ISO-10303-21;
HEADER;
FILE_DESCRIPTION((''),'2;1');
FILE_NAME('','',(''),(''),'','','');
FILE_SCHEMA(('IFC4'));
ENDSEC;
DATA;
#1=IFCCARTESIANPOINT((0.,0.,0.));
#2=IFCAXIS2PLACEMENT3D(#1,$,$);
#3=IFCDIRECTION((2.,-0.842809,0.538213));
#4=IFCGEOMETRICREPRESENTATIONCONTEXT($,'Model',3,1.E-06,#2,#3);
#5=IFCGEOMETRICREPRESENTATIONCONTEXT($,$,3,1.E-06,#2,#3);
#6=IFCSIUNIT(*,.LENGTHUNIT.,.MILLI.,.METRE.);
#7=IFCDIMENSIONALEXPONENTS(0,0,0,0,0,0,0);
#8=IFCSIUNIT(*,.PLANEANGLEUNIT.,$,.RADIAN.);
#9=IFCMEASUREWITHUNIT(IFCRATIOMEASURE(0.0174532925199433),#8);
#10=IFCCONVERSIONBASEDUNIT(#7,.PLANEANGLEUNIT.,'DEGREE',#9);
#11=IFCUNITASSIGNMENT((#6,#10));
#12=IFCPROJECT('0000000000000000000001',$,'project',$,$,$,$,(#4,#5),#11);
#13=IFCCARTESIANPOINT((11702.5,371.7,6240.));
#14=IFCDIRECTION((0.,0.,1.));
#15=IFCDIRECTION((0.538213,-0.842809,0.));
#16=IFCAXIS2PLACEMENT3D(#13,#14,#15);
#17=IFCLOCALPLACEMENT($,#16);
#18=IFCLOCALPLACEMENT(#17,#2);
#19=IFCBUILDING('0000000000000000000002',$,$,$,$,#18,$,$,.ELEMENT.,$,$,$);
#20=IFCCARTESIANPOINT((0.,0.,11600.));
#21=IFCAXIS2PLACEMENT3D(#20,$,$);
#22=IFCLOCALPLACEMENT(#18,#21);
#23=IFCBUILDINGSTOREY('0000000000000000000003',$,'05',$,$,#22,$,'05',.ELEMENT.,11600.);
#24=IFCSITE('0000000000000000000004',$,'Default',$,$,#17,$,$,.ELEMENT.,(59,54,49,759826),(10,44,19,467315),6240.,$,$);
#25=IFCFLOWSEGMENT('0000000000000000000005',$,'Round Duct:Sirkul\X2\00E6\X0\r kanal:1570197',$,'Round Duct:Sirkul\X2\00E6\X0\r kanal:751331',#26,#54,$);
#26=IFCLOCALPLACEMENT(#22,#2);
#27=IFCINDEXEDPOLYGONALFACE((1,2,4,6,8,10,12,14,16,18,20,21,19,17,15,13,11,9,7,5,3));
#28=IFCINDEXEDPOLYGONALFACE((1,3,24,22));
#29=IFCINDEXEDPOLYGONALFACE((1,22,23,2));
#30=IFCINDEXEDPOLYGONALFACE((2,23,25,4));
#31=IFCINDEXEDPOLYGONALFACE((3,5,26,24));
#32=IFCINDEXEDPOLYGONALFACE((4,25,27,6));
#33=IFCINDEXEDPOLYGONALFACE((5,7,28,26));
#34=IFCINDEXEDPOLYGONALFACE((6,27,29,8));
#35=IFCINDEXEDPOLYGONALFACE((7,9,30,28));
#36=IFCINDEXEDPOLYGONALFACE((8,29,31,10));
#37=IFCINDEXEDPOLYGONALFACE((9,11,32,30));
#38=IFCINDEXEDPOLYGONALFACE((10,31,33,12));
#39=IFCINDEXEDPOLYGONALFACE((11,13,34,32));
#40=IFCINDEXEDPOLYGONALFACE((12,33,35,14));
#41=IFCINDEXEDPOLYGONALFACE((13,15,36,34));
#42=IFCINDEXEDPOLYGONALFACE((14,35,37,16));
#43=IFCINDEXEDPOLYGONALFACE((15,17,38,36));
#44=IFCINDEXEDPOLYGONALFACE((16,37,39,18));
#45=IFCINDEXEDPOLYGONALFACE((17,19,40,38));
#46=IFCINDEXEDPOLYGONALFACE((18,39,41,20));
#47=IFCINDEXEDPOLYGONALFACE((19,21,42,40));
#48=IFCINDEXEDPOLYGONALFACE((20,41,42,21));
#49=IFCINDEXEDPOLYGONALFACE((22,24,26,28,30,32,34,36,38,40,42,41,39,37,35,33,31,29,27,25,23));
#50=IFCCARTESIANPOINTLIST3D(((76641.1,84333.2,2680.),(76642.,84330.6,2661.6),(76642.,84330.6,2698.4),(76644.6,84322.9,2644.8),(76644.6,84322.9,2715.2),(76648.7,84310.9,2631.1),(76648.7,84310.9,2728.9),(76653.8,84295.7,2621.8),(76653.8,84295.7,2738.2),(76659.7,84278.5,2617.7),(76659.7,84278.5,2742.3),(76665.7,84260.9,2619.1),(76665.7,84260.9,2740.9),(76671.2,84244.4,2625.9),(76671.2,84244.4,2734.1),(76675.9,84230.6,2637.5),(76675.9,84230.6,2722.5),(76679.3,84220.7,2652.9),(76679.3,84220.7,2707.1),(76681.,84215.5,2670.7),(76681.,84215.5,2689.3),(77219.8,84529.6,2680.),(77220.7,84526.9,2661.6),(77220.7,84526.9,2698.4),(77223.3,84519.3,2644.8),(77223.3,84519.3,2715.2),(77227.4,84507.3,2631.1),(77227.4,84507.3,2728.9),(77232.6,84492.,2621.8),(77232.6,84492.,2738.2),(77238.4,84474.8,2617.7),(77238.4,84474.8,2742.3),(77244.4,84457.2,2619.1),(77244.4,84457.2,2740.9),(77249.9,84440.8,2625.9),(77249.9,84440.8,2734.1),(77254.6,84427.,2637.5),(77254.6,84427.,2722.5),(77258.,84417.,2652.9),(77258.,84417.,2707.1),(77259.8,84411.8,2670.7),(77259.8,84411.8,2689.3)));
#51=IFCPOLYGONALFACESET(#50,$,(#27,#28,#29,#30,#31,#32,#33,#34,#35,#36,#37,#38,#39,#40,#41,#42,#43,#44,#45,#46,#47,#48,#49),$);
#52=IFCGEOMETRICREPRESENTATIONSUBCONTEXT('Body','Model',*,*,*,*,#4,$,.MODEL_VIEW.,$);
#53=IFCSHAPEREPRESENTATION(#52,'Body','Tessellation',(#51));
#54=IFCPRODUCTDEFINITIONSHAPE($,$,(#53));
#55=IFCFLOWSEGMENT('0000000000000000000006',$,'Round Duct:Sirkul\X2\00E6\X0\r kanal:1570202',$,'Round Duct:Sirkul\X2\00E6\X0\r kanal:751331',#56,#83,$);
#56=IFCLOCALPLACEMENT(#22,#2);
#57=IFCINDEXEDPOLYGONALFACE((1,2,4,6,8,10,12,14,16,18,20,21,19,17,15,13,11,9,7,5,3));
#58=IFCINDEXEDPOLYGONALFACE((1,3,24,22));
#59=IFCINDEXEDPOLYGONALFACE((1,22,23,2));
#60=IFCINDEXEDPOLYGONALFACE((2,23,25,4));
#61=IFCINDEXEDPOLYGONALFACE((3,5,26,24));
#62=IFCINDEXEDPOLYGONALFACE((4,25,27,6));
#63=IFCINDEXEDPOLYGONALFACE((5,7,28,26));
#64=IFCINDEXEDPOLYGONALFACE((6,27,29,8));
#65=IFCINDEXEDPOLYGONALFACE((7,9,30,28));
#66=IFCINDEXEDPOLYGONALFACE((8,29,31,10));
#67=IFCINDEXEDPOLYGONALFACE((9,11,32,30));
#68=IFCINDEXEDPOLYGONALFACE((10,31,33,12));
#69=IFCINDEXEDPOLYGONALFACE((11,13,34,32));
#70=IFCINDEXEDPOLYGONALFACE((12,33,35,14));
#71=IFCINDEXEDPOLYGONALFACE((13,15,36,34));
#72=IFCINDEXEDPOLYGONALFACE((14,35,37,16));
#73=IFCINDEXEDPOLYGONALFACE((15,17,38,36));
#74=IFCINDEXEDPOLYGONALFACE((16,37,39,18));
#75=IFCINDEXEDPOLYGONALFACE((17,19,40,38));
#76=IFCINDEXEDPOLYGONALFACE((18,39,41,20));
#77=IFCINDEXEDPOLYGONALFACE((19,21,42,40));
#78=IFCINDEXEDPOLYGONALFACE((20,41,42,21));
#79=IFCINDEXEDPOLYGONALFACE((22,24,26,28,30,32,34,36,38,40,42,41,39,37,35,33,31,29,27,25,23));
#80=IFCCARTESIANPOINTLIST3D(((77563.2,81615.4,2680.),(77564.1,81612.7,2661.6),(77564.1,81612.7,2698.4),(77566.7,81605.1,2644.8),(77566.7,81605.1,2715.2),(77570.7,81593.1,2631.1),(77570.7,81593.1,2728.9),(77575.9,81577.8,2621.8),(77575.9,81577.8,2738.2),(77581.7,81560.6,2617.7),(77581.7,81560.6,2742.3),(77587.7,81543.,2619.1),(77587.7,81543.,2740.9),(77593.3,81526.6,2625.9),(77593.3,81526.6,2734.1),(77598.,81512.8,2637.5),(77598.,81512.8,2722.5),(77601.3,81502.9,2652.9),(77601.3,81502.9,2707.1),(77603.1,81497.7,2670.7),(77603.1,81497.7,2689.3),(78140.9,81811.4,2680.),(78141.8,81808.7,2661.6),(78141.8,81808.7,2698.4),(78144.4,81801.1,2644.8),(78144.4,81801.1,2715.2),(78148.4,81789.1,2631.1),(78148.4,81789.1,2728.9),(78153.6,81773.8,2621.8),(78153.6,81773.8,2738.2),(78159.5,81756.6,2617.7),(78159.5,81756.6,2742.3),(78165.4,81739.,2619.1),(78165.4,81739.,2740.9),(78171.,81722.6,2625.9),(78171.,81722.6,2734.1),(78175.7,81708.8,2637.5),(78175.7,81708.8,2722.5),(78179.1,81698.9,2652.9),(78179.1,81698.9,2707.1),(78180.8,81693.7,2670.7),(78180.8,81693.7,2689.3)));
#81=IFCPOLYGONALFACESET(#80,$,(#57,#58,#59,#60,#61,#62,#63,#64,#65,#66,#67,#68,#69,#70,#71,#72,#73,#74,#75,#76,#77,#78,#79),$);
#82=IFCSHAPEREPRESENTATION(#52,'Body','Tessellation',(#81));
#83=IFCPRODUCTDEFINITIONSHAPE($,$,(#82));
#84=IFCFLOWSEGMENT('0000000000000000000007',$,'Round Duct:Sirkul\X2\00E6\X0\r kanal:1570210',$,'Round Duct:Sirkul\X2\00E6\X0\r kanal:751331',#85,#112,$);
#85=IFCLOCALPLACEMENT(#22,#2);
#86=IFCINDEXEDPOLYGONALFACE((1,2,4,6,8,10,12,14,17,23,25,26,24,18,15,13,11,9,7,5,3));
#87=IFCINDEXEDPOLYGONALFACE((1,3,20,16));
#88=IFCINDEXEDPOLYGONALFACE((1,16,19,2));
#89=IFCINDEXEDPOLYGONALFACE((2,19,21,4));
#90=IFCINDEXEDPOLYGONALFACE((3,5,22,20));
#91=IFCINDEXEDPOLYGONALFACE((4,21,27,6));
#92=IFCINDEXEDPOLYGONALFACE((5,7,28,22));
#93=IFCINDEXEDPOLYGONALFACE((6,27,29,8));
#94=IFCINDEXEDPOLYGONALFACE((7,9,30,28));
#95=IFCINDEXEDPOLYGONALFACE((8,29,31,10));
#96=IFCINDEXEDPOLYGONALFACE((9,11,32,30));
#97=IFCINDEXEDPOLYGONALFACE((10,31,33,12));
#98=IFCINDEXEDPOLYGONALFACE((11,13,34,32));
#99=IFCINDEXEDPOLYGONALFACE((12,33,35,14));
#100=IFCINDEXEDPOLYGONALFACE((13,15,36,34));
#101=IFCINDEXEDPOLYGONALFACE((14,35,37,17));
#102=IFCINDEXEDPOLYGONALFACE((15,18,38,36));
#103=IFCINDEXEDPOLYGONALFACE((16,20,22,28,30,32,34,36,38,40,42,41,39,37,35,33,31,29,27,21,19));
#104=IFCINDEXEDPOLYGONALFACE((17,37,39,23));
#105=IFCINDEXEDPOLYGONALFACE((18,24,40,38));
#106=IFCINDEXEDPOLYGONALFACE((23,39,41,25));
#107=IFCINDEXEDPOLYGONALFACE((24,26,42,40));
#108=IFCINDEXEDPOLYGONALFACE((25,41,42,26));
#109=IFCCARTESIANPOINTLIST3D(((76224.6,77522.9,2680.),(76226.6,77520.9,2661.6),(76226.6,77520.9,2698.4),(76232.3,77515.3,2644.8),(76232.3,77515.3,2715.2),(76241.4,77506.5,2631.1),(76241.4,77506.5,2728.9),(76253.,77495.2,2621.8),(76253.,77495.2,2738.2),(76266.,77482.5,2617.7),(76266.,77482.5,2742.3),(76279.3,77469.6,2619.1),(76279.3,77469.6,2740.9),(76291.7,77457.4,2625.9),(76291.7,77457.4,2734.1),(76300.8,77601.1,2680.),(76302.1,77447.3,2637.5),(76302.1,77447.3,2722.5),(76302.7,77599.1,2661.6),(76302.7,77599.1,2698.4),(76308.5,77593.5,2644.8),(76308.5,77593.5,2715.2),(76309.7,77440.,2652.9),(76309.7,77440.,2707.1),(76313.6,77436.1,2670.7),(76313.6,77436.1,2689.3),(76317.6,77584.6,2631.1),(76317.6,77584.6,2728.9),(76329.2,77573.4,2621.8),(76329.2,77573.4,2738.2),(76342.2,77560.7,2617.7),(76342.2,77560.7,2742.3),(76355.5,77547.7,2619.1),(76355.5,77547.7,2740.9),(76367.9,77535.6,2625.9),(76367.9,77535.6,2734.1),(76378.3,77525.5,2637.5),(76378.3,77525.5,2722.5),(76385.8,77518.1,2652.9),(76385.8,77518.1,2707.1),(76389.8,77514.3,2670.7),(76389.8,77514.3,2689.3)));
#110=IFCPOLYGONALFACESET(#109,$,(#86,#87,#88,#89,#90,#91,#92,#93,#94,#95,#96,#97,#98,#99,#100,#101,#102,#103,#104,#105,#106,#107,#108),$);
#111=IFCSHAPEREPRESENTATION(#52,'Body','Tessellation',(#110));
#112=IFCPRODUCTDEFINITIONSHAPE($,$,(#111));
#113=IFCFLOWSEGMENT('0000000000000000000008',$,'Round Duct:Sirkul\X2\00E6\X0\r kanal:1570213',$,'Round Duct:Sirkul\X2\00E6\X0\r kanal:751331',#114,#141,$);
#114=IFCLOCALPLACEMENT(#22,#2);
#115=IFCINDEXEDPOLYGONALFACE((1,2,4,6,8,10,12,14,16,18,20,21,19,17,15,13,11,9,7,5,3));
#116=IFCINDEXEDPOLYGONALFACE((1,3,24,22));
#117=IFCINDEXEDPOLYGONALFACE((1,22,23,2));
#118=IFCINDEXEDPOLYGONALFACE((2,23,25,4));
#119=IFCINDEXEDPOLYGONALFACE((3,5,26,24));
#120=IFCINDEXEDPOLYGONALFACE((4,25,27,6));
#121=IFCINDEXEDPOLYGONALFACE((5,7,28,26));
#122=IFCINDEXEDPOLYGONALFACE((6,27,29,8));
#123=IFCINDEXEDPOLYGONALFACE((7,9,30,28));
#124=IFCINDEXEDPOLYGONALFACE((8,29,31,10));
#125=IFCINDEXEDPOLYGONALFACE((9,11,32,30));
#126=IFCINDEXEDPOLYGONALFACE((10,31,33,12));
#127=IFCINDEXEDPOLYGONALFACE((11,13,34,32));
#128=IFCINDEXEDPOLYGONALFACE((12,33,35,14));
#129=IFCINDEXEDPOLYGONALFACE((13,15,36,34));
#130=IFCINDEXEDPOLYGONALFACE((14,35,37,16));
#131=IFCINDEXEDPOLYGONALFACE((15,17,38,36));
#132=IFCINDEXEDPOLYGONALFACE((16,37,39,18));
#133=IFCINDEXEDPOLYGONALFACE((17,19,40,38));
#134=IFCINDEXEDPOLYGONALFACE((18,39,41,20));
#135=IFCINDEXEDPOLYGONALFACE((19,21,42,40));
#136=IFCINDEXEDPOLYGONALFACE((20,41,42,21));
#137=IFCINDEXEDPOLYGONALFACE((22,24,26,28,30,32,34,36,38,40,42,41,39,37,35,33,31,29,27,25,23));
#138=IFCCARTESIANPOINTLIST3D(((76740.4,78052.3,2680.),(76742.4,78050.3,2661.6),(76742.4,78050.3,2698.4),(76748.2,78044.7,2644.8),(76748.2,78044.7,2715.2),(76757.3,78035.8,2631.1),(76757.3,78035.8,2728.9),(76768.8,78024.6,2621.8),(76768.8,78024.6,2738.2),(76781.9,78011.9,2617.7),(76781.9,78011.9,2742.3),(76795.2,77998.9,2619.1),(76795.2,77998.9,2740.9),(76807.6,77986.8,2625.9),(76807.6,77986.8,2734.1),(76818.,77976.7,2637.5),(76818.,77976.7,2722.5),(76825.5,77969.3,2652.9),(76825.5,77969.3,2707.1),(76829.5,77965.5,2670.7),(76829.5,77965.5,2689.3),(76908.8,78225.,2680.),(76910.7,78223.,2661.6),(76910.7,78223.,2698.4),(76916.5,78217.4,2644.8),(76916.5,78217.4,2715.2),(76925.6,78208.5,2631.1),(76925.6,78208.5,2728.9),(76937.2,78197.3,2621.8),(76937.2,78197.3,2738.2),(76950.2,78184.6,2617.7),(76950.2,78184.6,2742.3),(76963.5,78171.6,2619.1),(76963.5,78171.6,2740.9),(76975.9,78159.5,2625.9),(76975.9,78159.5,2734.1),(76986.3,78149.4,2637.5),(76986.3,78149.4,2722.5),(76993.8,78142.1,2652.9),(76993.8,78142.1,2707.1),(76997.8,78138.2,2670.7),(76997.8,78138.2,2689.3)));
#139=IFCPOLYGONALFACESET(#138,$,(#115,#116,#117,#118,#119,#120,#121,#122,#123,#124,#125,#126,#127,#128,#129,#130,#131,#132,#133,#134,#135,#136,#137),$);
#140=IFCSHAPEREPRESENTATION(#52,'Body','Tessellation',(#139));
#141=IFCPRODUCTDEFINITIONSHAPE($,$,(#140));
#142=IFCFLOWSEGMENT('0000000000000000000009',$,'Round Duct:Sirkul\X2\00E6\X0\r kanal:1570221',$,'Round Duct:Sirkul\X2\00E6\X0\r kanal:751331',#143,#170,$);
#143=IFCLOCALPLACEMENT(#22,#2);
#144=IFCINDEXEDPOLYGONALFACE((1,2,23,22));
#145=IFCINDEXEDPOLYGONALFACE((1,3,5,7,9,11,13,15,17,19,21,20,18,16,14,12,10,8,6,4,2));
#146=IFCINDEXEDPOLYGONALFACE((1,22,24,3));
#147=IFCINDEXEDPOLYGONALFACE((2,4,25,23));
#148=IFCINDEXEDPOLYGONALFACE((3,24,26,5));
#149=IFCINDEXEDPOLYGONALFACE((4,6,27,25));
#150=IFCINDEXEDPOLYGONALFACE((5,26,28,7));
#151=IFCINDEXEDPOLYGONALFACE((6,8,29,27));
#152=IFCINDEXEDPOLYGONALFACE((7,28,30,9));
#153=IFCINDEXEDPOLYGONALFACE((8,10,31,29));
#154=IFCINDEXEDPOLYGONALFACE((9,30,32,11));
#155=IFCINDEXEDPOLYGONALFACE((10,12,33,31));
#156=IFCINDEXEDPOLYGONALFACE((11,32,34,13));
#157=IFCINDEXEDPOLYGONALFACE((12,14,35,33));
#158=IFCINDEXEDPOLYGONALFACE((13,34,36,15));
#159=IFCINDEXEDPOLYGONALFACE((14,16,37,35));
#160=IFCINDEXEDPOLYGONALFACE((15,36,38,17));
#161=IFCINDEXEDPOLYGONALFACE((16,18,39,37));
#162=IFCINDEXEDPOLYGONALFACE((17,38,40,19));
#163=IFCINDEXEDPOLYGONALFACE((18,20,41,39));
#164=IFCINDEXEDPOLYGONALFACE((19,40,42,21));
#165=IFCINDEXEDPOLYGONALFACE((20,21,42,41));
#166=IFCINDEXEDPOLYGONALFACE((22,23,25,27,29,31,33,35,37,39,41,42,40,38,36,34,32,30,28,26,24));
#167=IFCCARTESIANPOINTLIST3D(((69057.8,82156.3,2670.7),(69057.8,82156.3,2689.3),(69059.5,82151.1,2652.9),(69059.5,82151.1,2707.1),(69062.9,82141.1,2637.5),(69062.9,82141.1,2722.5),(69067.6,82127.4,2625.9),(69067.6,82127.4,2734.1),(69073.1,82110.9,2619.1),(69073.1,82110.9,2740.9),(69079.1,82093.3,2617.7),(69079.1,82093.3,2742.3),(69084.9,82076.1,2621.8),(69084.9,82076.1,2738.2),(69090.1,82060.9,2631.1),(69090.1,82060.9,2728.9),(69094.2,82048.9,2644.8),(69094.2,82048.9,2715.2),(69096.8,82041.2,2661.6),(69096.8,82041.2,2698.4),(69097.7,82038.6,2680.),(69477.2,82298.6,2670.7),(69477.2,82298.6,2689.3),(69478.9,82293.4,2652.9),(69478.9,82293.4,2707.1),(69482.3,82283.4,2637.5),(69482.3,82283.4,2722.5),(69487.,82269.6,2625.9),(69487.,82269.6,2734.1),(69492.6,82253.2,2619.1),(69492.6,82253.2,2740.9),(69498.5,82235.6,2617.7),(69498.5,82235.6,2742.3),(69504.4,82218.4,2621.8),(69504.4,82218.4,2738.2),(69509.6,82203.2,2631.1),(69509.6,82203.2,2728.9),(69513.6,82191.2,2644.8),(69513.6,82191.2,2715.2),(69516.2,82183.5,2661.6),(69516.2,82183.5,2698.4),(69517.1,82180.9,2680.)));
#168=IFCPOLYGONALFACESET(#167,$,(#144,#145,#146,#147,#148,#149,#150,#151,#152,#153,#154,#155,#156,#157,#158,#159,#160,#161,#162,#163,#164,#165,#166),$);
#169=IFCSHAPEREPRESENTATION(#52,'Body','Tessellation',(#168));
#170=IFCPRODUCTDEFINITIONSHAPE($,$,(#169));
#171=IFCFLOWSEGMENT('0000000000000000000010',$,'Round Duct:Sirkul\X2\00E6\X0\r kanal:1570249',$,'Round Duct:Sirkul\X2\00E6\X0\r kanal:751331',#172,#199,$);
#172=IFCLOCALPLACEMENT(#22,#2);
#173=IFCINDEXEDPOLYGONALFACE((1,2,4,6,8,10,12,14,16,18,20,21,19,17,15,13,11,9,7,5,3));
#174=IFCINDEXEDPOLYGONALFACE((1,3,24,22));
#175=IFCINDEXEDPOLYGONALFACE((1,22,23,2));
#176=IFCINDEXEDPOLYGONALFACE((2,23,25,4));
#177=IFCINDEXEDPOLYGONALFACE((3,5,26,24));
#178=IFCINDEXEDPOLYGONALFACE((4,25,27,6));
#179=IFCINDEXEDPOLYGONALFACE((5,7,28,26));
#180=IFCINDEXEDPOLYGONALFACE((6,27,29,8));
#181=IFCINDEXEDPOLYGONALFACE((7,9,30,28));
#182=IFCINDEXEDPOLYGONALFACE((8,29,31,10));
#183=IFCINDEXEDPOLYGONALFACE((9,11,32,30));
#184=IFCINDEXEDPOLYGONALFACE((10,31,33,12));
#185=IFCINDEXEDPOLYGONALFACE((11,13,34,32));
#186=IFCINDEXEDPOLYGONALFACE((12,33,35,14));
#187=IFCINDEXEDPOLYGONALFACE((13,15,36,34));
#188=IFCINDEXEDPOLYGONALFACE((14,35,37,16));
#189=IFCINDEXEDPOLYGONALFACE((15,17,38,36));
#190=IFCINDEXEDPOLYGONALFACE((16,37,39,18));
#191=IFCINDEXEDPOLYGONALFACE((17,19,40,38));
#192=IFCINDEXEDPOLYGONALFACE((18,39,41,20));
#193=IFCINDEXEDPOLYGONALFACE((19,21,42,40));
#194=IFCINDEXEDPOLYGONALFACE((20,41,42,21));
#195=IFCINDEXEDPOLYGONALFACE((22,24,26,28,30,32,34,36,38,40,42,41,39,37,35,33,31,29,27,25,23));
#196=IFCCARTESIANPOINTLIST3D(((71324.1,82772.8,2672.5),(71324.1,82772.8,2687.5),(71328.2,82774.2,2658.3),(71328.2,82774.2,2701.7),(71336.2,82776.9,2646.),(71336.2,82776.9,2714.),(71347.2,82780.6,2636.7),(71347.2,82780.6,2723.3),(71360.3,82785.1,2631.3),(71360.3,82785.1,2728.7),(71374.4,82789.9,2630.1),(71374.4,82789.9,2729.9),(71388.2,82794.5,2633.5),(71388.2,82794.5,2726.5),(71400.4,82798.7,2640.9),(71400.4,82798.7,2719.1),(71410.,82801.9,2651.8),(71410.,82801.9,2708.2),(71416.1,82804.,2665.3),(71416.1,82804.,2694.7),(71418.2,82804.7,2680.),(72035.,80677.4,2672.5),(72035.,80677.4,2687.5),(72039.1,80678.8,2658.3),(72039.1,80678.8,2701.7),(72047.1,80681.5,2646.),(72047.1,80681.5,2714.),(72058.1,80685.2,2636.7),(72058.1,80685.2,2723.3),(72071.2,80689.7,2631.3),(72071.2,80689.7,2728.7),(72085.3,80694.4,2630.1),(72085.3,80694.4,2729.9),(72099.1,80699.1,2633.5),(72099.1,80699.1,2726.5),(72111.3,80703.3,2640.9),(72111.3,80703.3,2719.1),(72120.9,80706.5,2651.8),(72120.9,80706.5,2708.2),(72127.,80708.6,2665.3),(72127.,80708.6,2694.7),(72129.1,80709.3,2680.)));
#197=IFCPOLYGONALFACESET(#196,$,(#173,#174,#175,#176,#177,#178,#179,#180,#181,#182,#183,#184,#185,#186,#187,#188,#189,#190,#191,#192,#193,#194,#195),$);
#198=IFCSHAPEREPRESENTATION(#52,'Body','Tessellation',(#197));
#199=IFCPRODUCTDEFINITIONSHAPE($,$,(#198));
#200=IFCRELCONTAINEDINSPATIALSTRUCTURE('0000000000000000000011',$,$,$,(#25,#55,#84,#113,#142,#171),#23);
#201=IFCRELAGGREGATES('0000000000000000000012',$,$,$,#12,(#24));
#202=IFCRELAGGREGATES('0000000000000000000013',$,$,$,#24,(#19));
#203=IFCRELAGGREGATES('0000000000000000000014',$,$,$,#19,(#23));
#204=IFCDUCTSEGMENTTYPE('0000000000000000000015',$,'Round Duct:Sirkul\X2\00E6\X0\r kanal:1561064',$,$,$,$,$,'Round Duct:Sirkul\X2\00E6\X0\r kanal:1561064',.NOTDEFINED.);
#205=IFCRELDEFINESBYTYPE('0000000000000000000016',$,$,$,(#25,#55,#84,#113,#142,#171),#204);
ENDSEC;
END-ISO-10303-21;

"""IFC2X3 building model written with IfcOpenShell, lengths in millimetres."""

from ifc_helpers import new_model, entity, si_unit, converted_unit, direction, frame, frame_2d, origin, origin_2d_with_axis, place, context, subcontext, project, spatial, circle, extrude, type_object, element, save


model = new_model("IFC2X3")

# Units and contexts
model_context = context("Model", 3, precision=1e-06, world=origin(), true_north=direction((2.0, -0.842809, 0.538213)))
context_of_model = context(None, 3, precision=1e-06, world=origin(), true_north=direction((2.0, -0.842809, 0.538213)))
body_context = subcontext(model_context, "Body", "Model", "MODEL_VIEW")
ifc_project = project(units=[si_unit("LENGTHUNIT", "METRE", prefix="MILLI"), converted_unit("PLANEANGLEUNIT", "DEGREE", entity("IfcRatioMeasure", 0.0174532925199433), si_unit("PLANEANGLEUNIT", "RADIAN"), dimensions=[0, 0, 0, 0, 0, 0, 0])], contexts=[model_context, context_of_model])

# Site, building, storey
site_placement = place(None, frame((11702.5, 371.7, 6240.0), z_axis=(0.0, 0.0, 1.0), x_axis=(0.538213, -0.842809, 0.0)))
site = spatial("IfcSite", under=ifc_project, at=site_placement, Name="Default", CompositionType="ELEMENT", RefLatitude=(59, 54, 49, 759826), RefLongitude=(10, 44, 19, 467315), RefElevation=6240.0)
building_placement = place(site_placement, origin())
building = spatial("IfcBuilding", under=site, at=building_placement, CompositionType="ELEMENT")
storey_placement = place(building_placement, frame((0.0, 0.0, 11600.0)))
storey = spatial("IfcBuildingStorey", under=building, at=storey_placement, Name="05", LongName="05", CompositionType="ELEMENT", Elevation=11600.0)

# Flow segments
duct_segment_type = type_object("IfcDuctSegmentType", Name="Round Duct:Sirkulær kanal:1561064", ElementType="Round Duct:Sirkulær kanal:1561064", PredefinedType="NOTDEFINED")
flow_segment_1_placement = place(storey_placement, origin())
element("IfcFlowSegment", 1, at=flow_segment_1_placement, inside=storey, type_object=duct_segment_type, Name="Round Duct:Sirkulær kanal:1570197", ObjectType="Round Duct:Sirkulær kanal:751331", context=body_context, shape_type="SweptSolid", body=[
    extrude(circle(Radius=62.5, at=frame_2d((0.0, 0.0), x_axis=(1.0, 0.0))), frame((76661.2, 84274.0, 2680.0), z_axis=(0.946986, 0.321274, 0.0), x_axis=(-0.321274, 0.946986, 0.0)), (0.0, 0.0, 1.0), 611.1),
])
flow_segment_2_placement = place(storey_placement, origin())
element("IfcFlowSegment", 2, at=flow_segment_2_placement, inside=storey, type_object=duct_segment_type, Name="Round Duct:Sirkulær kanal:1570202", ObjectType="Round Duct:Sirkulær kanal:751331", context=body_context, shape_type="SweptSolid", body=[
    extrude(circle(Radius=62.5, at=frame_2d((0.0, 0.0), x_axis=(1.0, 0.0))), frame((77583.2, 81556.2, 2680.0), z_axis=(0.946986, 0.321274, 0.0), x_axis=(-0.321274, 0.946986, 0.0)), (0.0, 0.0, 1.0), 610.1),
])
flow_segment_3_placement = place(storey_placement, origin())
element("IfcFlowSegment", 3, at=flow_segment_3_placement, inside=storey, type_object=duct_segment_type, Name="Round Duct:Sirkulær kanal:1570210", ObjectType="Round Duct:Sirkulær kanal:751331", context=body_context, shape_type="SweptSolid", body=[
    extrude(circle(Radius=62.5, at=frame_2d((0.0, 0.0), x_axis=(1.0, 0.0))), frame((76269.3, 77479.3, 2680.0), z_axis=(0.697915, 0.71618, 0.0), x_axis=(-0.71618, 0.697915, 0.0)), (0.0, 0.0, 1.0), 109.2),
])
flow_segment_4_placement = place(storey_placement, origin())
element("IfcFlowSegment", 4, at=flow_segment_4_placement, inside=storey, type_object=duct_segment_type, Name="Round Duct:Sirkulær kanal:1570213", ObjectType="Round Duct:Sirkulær kanal:751331", context=body_context, shape_type="SweptSolid", body=[
    extrude(circle(Radius=62.5, at=frame_2d((0.0, 0.0), x_axis=(1.0, 0.0))), frame((76785.2, 78008.6, 2680.0), z_axis=(0.697915, 0.71618, 0.0), x_axis=(-0.71618, 0.697915, 0.0)), (0.0, 0.0, 1.0), 241.2),
])
flow_segment_5_placement = place(storey_placement, origin())
element("IfcFlowSegment", 5, at=flow_segment_5_placement, inside=storey, type_object=duct_segment_type, Name="Round Duct:Sirkulær kanal:1570221", ObjectType="Round Duct:Sirkulær kanal:751331", context=body_context, shape_type="SweptSolid", body=[
    extrude(circle(Radius=62.5, at=frame_2d((0.0, 0.0), x_axis=(1.0, 0.0))), frame((69077.6, 82097.8, 2680.0), z_axis=(0.946986, 0.321274, 0.0), x_axis=(0.321274, -0.946986, 0.0)), (0.0, 0.0, 1.0), 442.9),
])
flow_segment_6_placement = place(storey_placement, origin())
element("IfcFlowSegment", 6, at=flow_segment_6_placement, inside=storey, type_object=duct_segment_type, Name="Round Duct:Sirkulær kanal:1570249", ObjectType="Round Duct:Sirkulær kanal:751331", context=body_context, shape_type="SweptSolid", body=[
    extrude(circle(Radius=50.0, at=origin_2d_with_axis()), frame((71370.9, 82788.7, 2680.0), z_axis=(0.321274, -0.946986, 0.0), x_axis=(0.946986, 0.321274, 0.0)), (0.0, 0.0, 1.0), 2212.7),
])

save(model, "model.ifc")
